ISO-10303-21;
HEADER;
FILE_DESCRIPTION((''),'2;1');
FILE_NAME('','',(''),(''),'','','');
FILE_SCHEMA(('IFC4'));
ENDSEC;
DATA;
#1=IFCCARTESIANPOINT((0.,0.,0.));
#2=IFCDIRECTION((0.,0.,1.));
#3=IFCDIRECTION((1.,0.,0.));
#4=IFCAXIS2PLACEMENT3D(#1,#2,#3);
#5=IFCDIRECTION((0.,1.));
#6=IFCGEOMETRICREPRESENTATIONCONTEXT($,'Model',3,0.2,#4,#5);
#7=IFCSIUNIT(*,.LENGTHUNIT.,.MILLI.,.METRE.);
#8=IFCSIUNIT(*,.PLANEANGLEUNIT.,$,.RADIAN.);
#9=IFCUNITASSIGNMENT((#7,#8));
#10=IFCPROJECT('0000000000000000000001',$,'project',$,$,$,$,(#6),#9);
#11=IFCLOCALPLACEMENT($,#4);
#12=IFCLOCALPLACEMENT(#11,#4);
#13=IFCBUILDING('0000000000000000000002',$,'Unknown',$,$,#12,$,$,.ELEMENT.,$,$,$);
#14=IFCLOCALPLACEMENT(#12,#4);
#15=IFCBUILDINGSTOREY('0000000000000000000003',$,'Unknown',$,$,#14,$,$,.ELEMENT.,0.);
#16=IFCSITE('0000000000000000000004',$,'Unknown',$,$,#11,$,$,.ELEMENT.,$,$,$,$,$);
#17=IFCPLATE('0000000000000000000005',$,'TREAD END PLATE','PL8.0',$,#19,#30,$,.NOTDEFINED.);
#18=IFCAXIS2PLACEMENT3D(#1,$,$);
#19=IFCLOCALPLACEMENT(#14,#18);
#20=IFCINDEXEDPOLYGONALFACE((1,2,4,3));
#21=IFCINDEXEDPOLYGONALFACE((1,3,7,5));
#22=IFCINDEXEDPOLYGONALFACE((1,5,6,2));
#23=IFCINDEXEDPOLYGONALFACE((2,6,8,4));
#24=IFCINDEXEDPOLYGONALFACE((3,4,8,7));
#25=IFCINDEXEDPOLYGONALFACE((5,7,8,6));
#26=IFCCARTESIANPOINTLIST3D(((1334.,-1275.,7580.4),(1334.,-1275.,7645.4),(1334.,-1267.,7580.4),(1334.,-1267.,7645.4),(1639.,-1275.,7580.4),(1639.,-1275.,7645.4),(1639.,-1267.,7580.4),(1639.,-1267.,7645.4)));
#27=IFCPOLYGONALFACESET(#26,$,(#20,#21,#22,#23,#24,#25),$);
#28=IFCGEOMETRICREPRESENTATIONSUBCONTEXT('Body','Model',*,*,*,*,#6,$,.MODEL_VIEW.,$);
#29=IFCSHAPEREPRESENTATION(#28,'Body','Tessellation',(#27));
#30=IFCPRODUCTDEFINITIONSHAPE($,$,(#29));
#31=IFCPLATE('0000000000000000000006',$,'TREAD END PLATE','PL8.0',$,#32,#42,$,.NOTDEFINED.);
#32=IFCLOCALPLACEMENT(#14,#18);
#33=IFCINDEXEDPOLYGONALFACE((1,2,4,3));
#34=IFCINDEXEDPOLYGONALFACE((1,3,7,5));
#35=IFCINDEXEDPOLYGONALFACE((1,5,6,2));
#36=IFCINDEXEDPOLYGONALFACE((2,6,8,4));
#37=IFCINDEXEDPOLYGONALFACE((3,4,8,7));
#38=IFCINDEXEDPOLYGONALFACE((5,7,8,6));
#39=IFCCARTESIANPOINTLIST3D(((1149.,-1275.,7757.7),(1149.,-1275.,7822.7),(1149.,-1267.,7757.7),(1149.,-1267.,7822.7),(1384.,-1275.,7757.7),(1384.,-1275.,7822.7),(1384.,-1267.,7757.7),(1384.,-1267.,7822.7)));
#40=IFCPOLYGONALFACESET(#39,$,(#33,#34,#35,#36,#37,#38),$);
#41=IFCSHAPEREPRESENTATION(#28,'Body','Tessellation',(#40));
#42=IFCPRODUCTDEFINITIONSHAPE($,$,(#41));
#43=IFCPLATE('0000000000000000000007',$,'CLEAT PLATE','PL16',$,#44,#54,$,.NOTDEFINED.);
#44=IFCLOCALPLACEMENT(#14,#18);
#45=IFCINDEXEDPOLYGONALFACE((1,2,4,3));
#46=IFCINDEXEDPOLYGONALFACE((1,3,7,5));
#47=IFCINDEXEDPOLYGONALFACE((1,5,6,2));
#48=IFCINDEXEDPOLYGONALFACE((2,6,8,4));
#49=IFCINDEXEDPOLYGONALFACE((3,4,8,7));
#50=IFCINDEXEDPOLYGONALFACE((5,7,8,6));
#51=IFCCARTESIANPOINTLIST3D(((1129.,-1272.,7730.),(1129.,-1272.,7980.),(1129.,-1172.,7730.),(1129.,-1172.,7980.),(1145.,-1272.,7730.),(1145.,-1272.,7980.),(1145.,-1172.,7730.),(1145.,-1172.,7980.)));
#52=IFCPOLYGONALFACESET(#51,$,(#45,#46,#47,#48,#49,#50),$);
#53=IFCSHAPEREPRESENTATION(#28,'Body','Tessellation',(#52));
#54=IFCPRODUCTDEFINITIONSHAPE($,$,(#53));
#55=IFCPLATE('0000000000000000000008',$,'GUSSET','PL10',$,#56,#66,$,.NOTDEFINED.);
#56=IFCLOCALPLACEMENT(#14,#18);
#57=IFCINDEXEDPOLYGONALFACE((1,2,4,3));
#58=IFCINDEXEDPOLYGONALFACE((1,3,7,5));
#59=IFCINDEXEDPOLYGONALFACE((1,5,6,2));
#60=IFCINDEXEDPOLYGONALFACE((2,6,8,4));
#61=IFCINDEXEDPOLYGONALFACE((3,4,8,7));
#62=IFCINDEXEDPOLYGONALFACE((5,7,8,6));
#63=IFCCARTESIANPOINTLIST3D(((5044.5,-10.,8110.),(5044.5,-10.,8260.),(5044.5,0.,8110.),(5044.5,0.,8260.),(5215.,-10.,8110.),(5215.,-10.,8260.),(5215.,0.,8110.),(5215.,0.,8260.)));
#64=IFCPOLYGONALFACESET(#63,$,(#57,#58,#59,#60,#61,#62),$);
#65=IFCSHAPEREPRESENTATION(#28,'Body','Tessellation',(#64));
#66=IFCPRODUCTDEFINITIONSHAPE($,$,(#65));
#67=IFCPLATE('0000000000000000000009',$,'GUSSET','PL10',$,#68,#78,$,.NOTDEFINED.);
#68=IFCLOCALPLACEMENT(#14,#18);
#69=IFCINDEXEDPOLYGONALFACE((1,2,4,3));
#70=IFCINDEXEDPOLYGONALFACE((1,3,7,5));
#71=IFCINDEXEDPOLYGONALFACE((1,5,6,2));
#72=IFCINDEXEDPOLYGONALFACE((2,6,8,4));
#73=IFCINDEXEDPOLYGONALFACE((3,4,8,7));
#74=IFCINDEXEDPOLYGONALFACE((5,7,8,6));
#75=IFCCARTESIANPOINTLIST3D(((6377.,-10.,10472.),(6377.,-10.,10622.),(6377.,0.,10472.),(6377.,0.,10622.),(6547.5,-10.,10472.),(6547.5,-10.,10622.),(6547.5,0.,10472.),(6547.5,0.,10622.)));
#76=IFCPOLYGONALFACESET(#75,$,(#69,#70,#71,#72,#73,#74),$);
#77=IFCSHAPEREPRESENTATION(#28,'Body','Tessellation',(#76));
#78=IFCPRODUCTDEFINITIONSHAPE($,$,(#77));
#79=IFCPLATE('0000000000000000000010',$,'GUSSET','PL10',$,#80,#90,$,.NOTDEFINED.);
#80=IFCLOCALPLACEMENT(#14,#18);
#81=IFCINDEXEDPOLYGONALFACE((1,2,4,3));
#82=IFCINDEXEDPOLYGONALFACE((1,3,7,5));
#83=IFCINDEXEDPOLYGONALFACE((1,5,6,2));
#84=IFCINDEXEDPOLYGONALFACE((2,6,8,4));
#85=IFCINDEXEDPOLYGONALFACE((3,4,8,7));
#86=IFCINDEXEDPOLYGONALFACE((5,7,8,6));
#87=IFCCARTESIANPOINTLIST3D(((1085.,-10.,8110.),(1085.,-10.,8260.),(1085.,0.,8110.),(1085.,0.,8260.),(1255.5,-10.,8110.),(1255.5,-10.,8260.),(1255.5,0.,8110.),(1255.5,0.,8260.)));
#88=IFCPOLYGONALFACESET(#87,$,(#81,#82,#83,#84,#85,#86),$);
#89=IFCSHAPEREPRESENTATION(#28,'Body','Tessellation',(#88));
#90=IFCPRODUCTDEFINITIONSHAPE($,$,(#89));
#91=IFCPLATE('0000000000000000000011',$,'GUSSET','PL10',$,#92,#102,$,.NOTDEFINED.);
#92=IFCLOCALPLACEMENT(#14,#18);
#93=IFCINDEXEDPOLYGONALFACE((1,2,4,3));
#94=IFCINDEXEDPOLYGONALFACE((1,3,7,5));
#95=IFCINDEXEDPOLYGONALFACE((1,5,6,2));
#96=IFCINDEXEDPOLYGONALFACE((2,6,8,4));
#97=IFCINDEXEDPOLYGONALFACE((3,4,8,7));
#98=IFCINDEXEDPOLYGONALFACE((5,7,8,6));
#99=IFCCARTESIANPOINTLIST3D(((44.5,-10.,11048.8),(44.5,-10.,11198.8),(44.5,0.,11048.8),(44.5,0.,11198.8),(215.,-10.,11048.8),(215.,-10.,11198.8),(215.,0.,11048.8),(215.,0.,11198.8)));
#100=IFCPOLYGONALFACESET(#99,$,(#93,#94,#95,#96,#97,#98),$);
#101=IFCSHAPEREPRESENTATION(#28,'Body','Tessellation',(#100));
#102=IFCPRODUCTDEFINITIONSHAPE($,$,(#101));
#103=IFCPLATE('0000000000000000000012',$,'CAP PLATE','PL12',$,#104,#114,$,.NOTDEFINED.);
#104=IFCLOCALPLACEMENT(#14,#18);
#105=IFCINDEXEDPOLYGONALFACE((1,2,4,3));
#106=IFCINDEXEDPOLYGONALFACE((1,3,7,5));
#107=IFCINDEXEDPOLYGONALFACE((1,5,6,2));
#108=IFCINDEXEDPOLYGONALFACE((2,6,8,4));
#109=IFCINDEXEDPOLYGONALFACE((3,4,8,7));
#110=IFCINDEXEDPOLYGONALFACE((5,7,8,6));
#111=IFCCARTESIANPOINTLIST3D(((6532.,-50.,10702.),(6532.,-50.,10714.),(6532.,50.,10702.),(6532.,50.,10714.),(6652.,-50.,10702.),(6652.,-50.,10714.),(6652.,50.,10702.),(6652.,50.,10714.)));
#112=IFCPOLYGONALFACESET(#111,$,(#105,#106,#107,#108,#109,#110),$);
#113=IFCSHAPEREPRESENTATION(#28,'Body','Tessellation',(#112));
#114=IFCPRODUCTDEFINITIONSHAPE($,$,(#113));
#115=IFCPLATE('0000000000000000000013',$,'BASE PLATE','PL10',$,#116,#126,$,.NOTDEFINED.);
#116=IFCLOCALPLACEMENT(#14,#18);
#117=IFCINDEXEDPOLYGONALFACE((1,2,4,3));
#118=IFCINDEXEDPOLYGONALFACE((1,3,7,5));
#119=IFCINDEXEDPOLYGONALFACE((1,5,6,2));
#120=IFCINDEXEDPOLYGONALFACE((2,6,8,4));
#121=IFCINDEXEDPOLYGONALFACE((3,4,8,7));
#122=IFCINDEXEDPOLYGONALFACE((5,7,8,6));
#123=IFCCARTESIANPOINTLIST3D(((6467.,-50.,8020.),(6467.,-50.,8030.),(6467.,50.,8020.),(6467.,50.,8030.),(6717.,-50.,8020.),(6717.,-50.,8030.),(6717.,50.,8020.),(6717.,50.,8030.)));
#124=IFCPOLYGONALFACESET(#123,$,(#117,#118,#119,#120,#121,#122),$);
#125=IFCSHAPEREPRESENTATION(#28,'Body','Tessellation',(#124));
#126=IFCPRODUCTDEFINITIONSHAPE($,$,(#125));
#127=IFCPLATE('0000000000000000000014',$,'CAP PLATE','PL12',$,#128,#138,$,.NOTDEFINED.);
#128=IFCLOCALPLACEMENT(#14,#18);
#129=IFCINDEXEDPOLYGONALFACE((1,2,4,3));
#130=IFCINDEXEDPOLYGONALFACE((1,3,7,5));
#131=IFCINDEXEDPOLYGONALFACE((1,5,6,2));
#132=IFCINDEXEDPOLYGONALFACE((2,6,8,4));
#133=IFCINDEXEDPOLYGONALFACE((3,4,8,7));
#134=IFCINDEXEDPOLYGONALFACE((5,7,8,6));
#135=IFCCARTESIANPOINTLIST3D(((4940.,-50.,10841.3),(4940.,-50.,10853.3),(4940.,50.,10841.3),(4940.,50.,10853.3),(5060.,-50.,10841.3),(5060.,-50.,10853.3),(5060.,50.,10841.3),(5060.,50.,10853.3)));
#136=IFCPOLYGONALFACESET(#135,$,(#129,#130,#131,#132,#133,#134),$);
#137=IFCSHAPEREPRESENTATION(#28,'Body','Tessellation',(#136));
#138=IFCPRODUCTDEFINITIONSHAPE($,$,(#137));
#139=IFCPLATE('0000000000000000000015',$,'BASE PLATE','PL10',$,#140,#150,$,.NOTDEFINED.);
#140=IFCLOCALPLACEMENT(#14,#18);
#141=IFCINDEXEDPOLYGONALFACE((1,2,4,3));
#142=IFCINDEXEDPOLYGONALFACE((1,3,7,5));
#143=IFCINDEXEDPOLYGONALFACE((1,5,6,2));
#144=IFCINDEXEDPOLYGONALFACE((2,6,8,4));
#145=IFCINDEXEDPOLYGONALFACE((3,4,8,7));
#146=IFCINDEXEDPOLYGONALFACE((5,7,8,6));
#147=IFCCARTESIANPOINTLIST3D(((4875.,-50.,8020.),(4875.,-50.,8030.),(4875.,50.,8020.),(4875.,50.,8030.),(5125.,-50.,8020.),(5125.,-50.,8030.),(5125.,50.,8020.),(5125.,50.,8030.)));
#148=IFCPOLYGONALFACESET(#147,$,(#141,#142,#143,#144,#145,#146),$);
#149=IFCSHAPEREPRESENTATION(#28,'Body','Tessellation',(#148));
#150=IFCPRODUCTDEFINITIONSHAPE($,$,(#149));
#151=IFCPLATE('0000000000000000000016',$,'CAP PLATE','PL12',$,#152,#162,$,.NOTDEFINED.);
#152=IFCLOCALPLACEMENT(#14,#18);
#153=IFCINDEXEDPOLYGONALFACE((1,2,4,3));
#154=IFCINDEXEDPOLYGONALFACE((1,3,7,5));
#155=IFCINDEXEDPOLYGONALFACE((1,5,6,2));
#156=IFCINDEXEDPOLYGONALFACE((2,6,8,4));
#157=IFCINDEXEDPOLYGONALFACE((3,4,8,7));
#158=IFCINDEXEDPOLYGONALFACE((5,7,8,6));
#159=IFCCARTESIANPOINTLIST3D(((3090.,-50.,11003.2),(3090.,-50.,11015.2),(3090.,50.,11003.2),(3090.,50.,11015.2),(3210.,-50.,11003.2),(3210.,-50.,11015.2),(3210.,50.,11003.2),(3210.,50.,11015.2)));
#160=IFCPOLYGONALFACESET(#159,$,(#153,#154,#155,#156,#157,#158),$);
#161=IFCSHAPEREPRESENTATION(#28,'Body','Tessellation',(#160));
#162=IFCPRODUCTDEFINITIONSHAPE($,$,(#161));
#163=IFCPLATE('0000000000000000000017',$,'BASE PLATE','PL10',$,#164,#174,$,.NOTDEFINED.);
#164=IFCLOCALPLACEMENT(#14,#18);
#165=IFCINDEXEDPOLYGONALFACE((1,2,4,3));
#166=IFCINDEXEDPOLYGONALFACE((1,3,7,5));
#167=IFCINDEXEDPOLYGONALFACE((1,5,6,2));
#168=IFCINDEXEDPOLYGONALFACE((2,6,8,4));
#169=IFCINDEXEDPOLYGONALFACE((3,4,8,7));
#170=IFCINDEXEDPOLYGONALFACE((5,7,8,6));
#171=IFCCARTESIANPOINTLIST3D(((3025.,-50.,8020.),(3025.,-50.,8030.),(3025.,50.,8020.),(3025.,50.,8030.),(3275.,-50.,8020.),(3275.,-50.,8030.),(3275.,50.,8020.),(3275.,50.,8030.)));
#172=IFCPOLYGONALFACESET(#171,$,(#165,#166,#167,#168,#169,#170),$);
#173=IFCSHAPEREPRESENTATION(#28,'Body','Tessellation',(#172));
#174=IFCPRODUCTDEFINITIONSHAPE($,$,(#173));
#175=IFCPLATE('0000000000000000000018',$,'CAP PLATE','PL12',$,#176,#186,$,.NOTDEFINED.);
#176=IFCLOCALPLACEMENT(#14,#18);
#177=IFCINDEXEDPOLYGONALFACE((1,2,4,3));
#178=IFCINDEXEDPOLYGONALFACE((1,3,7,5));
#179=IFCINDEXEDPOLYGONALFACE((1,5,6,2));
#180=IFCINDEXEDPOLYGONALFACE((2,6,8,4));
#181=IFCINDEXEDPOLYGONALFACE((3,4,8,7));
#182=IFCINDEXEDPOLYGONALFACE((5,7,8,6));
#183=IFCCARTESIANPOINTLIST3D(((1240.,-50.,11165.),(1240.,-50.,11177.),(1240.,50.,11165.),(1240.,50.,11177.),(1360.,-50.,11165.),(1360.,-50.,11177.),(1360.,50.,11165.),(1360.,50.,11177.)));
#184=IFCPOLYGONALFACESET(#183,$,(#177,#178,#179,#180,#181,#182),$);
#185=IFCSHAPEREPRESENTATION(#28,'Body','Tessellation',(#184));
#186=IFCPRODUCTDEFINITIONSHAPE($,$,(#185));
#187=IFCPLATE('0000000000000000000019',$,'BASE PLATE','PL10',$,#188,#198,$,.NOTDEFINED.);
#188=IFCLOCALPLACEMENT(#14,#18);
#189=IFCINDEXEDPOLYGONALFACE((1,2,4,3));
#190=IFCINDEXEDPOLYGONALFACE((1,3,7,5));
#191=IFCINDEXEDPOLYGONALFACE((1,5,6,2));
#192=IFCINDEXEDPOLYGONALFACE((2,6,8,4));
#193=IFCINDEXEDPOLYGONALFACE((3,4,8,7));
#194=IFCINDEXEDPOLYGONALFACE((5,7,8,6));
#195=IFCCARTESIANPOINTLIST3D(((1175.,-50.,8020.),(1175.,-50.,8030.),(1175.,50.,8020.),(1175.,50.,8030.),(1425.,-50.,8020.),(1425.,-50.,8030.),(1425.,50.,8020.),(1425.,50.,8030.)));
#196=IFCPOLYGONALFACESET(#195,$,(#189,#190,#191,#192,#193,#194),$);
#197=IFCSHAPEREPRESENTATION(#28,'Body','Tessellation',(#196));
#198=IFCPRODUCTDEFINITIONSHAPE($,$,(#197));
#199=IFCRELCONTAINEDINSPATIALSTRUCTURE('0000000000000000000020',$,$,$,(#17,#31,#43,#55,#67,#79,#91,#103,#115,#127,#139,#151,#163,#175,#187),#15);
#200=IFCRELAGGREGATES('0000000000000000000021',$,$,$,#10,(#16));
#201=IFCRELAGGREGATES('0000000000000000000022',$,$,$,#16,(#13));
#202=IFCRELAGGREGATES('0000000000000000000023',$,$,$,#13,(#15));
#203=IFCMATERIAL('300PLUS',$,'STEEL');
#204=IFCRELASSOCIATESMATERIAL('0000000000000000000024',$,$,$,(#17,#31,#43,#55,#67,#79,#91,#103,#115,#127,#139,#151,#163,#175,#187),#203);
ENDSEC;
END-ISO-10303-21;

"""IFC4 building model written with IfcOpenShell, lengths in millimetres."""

from ifc_helpers import new_model, si_unit, direction, frame, origin_with_axes, place, context, subcontext, project, spatial, line, indexed_curve, outline, extrude, material, element, save


model = new_model("IFC4")

# Units and contexts
model_context = context("Model", 3, precision=0.2, world=origin_with_axes(), true_north=direction((0.0, 1.0)))
body_context = subcontext(model_context, "Body", "Model", "MODEL_VIEW")
ifc_project = project(units=[si_unit("LENGTHUNIT", "METRE", prefix="MILLI"), si_unit("PLANEANGLEUNIT", "RADIAN")], contexts=[model_context])

# Site, building, storey
site_placement = place(None, origin_with_axes())
site = spatial("IfcSite", under=ifc_project, at=site_placement, Name="Unknown", CompositionType="ELEMENT")
building_placement = place(site_placement, origin_with_axes())
building = spatial("IfcBuilding", under=site, at=building_placement, Name="Unknown", CompositionType="ELEMENT")
storey_placement = place(building_placement, origin_with_axes())
storey = spatial("IfcBuildingStorey", under=building, at=storey_placement, Name="Unknown", CompositionType="ELEMENT", Elevation=0.0)

# Plates
ifc_material_1 = material(Name="300PLUS", Category="STEEL")
plate_1_placement = place(storey_placement, frame((1334.0, -1271.0, 7580.4), z_axis=(0.0, -1.0, 0.0), x_axis=(1.0, 0.0, 0.0)))
element("IfcPlate", 1, at=plate_1_placement, inside=storey, material=ifc_material_1, Name="TREAD END PLATE", Description="PL8.0", PredefinedType="NOTDEFINED", context=body_context, shape_type="SolidModel", body=[
    extrude(outline(indexed_curve([(0.0, 0.0), (305.0, 0.0), (305.0, 65.0), (0.0, 65.0)], segments=[line(1, 2, 3, 4, 1)])), frame((0.0, 0.0, 4.0), z_axis=(0.0, 0.0, 1.0), x_axis=(1.0, 0.0, 0.0)), (0.0, 0.0, -1.0), 8.0),
])
plate_2_placement = place(storey_placement, frame((1149.0, -1271.0, 7757.7), z_axis=(0.0, -1.0, 0.0), x_axis=(1.0, 0.0, 0.0)))
element("IfcPlate", 2, at=plate_2_placement, inside=storey, material=ifc_material_1, Name="TREAD END PLATE", Description="PL8.0", PredefinedType="NOTDEFINED", context=body_context, shape_type="SolidModel", body=[
    extrude(outline(indexed_curve([(0.0, 0.0), (235.0, 0.0), (235.0, 65.0), (0.0, 65.0)], segments=[line(1, 2, 3, 4, 1)])), frame((0.0, 0.0, 4.0), z_axis=(0.0, 0.0, 1.0), x_axis=(1.0, 0.0, 0.0)), (0.0, 0.0, -1.0), 8.0),
])
plate_3_placement = place(storey_placement, frame((1137.0, -1272.0, 7730.0), z_axis=(1.0, 0.0, 0.0), x_axis=(0.0, 1.0, 0.0)))
element("IfcPlate", 3, at=plate_3_placement, inside=storey, material=ifc_material_1, Name="CLEAT PLATE", Description="PL16", PredefinedType="NOTDEFINED", context=body_context, shape_type="SolidModel", body=[
    extrude(outline(indexed_curve([(0.0, 0.0), (100.0, 0.0), (100.0, 250.0), (0.0, 250.0)], segments=[line(1, 2, 3, 4, 1)])), frame((0.0, 0.0, 8.0), z_axis=(0.0, 0.0, 1.0), x_axis=(1.0, 0.0, 0.0)), (0.0, 0.0, -1.0), 16.0),
])
for number, where, z_axis, x_axis, name in (
    (4, (5044.5, -5.0, 8110.0), (0.0, -1.0, 0.0), (1.0, 0.0, 0.0), "GUSSET"),
    (5, (6547.5, -5.0, 10622.0), (0.0, -1.0, 0.0), (-1.0, 0.0, 0.0), "GUSSET"),
    (6, (1255.5, -5.0, 8260.0), (0.0, -1.0, 0.0), (-1.0, 0.0, 0.0), "GUSSET"),
    (7, (44.5, -5.0, 11048.8), (0.0, -1.0, 0.0), (1.0, 0.0, 0.0), "GUSSET"),
):
    element("IfcPlate", number, at=place(storey_placement, frame(where, z_axis=z_axis, x_axis=x_axis)), inside=storey, material=ifc_material_1, Name=name, Description="PL10", PredefinedType="NOTDEFINED", context=body_context, shape_type="SolidModel", body=[
        extrude(outline(indexed_curve([(0.0, 0.0), (170.5, 0.0), (170.5, 150.0), (0.0, 150.0)], segments=[line(1, 2, 3, 4, 1)])), frame((0.0, 0.0, 5.0), z_axis=(0.0, 0.0, 1.0), x_axis=(1.0, 0.0, 0.0)), (0.0, 0.0, -1.0), 10.0),
    ])
plate_4_placement = place(storey_placement, frame((6532.0, -50.0, 10708.0), z_axis=(0.0, 0.0, 1.0), x_axis=(1.0, 0.0, 0.0)))
element("IfcPlate", 8, at=plate_4_placement, inside=storey, material=ifc_material_1, Name="CAP PLATE", Description="PL12", PredefinedType="NOTDEFINED", context=body_context, shape_type="SolidModel", body=[
    extrude(outline(indexed_curve([(0.0, 0.0), (120.0, 0.0), (120.0, 100.0), (0.0, 100.0)], segments=[line(1, 2, 3, 4, 1)])), frame((0.0, 0.0, 6.0), z_axis=(0.0, 0.0, 1.0), x_axis=(1.0, 0.0, 0.0)), (0.0, 0.0, -1.0), 12.0),
])
plate_5_placement = place(storey_placement, frame((6467.0, -50.0, 8025.0), z_axis=(0.0, 0.0, 1.0), x_axis=(1.0, 0.0, 0.0)))
element("IfcPlate", 9, at=plate_5_placement, inside=storey, material=ifc_material_1, Name="BASE PLATE", Description="PL10", PredefinedType="NOTDEFINED", context=body_context, shape_type="SolidModel", body=[
    extrude(outline(indexed_curve([(0.0, 0.0), (250.0, 0.0), (250.0, 100.0), (0.0, 100.0)], segments=[line(1, 2, 3, 4, 1)])), frame((0.0, 0.0, 5.0), z_axis=(0.0, 0.0, 1.0), x_axis=(1.0, 0.0, 0.0)), (0.0, 0.0, -1.0), 10.0),
])
plate_6_placement = place(storey_placement, frame((4940.0, -50.0, 10847.3), z_axis=(0.0, 0.0, 1.0), x_axis=(1.0, 0.0, 0.0)))
element("IfcPlate", 10, at=plate_6_placement, inside=storey, material=ifc_material_1, Name="CAP PLATE", Description="PL12", PredefinedType="NOTDEFINED", context=body_context, shape_type="SolidModel", body=[
    extrude(outline(indexed_curve([(0.0, 0.0), (120.0, 0.0), (120.0, 100.0), (0.0, 100.0)], segments=[line(1, 2, 3, 4, 1)])), frame((0.0, 0.0, 6.0), z_axis=(0.0, 0.0, 1.0), x_axis=(1.0, 0.0, 0.0)), (0.0, 0.0, -1.0), 12.0),
])
plate_7_placement = place(storey_placement, frame((4875.0, -50.0, 8025.0), z_axis=(0.0, 0.0, 1.0), x_axis=(1.0, 0.0, 0.0)))
element("IfcPlate", 11, at=plate_7_placement, inside=storey, material=ifc_material_1, Name="BASE PLATE", Description="PL10", PredefinedType="NOTDEFINED", context=body_context, shape_type="SolidModel", body=[
    extrude(outline(indexed_curve([(0.0, 0.0), (250.0, 0.0), (250.0, 100.0), (0.0, 100.0)], segments=[line(1, 2, 3, 4, 1)])), frame((0.0, 0.0, 5.0), z_axis=(0.0, 0.0, 1.0), x_axis=(1.0, 0.0, 0.0)), (0.0, 0.0, -1.0), 10.0),
])
plate_8_placement = place(storey_placement, frame((3090.0, -50.0, 11009.2), z_axis=(0.0, 0.0, 1.0), x_axis=(1.0, 0.0, 0.0)))
element("IfcPlate", 12, at=plate_8_placement, inside=storey, material=ifc_material_1, Name="CAP PLATE", Description="PL12", PredefinedType="NOTDEFINED", context=body_context, shape_type="SolidModel", body=[
    extrude(outline(indexed_curve([(0.0, 0.0), (120.0, 0.0), (120.0, 100.0), (0.0, 100.0)], segments=[line(1, 2, 3, 4, 1)])), frame((0.0, 0.0, 6.0), z_axis=(0.0, 0.0, 1.0), x_axis=(1.0, 0.0, 0.0)), (0.0, 0.0, -1.0), 12.0),
])
plate_9_placement = place(storey_placement, frame((3025.0, -50.0, 8025.0), z_axis=(0.0, 0.0, 1.0), x_axis=(1.0, 0.0, 0.0)))
element("IfcPlate", 13, at=plate_9_placement, inside=storey, material=ifc_material_1, Name="BASE PLATE", Description="PL10", PredefinedType="NOTDEFINED", context=body_context, shape_type="SolidModel", body=[
    extrude(outline(indexed_curve([(0.0, 0.0), (250.0, 0.0), (250.0, 100.0), (0.0, 100.0)], segments=[line(1, 2, 3, 4, 1)])), frame((0.0, 0.0, 5.0), z_axis=(0.0, 0.0, 1.0), x_axis=(1.0, 0.0, 0.0)), (0.0, 0.0, -1.0), 10.0),
])
plate_10_placement = place(storey_placement, frame((1240.0, -50.0, 11171.0), z_axis=(0.0, 0.0, 1.0), x_axis=(1.0, 0.0, 0.0)))
element("IfcPlate", 14, at=plate_10_placement, inside=storey, material=ifc_material_1, Name="CAP PLATE", Description="PL12", PredefinedType="NOTDEFINED", context=body_context, shape_type="SolidModel", body=[
    extrude(outline(indexed_curve([(0.0, 0.0), (120.0, 0.0), (120.0, 100.0), (0.0, 100.0)], segments=[line(1, 2, 3, 4, 1)])), frame((0.0, 0.0, 6.0), z_axis=(0.0, 0.0, 1.0), x_axis=(1.0, 0.0, 0.0)), (0.0, 0.0, -1.0), 12.0),
])
plate_11_placement = place(storey_placement, frame((1175.0, -50.0, 8025.0), z_axis=(0.0, 0.0, 1.0), x_axis=(1.0, 0.0, 0.0)))
element("IfcPlate", 15, at=plate_11_placement, inside=storey, material=ifc_material_1, Name="BASE PLATE", Description="PL10", PredefinedType="NOTDEFINED", context=body_context, shape_type="SolidModel", body=[
    extrude(outline(indexed_curve([(0.0, 0.0), (250.0, 0.0), (250.0, 100.0), (0.0, 100.0)], segments=[line(1, 2, 3, 4, 1)])), frame((0.0, 0.0, 5.0), z_axis=(0.0, 0.0, 1.0), x_axis=(1.0, 0.0, 0.0)), (0.0, 0.0, -1.0), 10.0),
])

save(model, "model.ifc")
